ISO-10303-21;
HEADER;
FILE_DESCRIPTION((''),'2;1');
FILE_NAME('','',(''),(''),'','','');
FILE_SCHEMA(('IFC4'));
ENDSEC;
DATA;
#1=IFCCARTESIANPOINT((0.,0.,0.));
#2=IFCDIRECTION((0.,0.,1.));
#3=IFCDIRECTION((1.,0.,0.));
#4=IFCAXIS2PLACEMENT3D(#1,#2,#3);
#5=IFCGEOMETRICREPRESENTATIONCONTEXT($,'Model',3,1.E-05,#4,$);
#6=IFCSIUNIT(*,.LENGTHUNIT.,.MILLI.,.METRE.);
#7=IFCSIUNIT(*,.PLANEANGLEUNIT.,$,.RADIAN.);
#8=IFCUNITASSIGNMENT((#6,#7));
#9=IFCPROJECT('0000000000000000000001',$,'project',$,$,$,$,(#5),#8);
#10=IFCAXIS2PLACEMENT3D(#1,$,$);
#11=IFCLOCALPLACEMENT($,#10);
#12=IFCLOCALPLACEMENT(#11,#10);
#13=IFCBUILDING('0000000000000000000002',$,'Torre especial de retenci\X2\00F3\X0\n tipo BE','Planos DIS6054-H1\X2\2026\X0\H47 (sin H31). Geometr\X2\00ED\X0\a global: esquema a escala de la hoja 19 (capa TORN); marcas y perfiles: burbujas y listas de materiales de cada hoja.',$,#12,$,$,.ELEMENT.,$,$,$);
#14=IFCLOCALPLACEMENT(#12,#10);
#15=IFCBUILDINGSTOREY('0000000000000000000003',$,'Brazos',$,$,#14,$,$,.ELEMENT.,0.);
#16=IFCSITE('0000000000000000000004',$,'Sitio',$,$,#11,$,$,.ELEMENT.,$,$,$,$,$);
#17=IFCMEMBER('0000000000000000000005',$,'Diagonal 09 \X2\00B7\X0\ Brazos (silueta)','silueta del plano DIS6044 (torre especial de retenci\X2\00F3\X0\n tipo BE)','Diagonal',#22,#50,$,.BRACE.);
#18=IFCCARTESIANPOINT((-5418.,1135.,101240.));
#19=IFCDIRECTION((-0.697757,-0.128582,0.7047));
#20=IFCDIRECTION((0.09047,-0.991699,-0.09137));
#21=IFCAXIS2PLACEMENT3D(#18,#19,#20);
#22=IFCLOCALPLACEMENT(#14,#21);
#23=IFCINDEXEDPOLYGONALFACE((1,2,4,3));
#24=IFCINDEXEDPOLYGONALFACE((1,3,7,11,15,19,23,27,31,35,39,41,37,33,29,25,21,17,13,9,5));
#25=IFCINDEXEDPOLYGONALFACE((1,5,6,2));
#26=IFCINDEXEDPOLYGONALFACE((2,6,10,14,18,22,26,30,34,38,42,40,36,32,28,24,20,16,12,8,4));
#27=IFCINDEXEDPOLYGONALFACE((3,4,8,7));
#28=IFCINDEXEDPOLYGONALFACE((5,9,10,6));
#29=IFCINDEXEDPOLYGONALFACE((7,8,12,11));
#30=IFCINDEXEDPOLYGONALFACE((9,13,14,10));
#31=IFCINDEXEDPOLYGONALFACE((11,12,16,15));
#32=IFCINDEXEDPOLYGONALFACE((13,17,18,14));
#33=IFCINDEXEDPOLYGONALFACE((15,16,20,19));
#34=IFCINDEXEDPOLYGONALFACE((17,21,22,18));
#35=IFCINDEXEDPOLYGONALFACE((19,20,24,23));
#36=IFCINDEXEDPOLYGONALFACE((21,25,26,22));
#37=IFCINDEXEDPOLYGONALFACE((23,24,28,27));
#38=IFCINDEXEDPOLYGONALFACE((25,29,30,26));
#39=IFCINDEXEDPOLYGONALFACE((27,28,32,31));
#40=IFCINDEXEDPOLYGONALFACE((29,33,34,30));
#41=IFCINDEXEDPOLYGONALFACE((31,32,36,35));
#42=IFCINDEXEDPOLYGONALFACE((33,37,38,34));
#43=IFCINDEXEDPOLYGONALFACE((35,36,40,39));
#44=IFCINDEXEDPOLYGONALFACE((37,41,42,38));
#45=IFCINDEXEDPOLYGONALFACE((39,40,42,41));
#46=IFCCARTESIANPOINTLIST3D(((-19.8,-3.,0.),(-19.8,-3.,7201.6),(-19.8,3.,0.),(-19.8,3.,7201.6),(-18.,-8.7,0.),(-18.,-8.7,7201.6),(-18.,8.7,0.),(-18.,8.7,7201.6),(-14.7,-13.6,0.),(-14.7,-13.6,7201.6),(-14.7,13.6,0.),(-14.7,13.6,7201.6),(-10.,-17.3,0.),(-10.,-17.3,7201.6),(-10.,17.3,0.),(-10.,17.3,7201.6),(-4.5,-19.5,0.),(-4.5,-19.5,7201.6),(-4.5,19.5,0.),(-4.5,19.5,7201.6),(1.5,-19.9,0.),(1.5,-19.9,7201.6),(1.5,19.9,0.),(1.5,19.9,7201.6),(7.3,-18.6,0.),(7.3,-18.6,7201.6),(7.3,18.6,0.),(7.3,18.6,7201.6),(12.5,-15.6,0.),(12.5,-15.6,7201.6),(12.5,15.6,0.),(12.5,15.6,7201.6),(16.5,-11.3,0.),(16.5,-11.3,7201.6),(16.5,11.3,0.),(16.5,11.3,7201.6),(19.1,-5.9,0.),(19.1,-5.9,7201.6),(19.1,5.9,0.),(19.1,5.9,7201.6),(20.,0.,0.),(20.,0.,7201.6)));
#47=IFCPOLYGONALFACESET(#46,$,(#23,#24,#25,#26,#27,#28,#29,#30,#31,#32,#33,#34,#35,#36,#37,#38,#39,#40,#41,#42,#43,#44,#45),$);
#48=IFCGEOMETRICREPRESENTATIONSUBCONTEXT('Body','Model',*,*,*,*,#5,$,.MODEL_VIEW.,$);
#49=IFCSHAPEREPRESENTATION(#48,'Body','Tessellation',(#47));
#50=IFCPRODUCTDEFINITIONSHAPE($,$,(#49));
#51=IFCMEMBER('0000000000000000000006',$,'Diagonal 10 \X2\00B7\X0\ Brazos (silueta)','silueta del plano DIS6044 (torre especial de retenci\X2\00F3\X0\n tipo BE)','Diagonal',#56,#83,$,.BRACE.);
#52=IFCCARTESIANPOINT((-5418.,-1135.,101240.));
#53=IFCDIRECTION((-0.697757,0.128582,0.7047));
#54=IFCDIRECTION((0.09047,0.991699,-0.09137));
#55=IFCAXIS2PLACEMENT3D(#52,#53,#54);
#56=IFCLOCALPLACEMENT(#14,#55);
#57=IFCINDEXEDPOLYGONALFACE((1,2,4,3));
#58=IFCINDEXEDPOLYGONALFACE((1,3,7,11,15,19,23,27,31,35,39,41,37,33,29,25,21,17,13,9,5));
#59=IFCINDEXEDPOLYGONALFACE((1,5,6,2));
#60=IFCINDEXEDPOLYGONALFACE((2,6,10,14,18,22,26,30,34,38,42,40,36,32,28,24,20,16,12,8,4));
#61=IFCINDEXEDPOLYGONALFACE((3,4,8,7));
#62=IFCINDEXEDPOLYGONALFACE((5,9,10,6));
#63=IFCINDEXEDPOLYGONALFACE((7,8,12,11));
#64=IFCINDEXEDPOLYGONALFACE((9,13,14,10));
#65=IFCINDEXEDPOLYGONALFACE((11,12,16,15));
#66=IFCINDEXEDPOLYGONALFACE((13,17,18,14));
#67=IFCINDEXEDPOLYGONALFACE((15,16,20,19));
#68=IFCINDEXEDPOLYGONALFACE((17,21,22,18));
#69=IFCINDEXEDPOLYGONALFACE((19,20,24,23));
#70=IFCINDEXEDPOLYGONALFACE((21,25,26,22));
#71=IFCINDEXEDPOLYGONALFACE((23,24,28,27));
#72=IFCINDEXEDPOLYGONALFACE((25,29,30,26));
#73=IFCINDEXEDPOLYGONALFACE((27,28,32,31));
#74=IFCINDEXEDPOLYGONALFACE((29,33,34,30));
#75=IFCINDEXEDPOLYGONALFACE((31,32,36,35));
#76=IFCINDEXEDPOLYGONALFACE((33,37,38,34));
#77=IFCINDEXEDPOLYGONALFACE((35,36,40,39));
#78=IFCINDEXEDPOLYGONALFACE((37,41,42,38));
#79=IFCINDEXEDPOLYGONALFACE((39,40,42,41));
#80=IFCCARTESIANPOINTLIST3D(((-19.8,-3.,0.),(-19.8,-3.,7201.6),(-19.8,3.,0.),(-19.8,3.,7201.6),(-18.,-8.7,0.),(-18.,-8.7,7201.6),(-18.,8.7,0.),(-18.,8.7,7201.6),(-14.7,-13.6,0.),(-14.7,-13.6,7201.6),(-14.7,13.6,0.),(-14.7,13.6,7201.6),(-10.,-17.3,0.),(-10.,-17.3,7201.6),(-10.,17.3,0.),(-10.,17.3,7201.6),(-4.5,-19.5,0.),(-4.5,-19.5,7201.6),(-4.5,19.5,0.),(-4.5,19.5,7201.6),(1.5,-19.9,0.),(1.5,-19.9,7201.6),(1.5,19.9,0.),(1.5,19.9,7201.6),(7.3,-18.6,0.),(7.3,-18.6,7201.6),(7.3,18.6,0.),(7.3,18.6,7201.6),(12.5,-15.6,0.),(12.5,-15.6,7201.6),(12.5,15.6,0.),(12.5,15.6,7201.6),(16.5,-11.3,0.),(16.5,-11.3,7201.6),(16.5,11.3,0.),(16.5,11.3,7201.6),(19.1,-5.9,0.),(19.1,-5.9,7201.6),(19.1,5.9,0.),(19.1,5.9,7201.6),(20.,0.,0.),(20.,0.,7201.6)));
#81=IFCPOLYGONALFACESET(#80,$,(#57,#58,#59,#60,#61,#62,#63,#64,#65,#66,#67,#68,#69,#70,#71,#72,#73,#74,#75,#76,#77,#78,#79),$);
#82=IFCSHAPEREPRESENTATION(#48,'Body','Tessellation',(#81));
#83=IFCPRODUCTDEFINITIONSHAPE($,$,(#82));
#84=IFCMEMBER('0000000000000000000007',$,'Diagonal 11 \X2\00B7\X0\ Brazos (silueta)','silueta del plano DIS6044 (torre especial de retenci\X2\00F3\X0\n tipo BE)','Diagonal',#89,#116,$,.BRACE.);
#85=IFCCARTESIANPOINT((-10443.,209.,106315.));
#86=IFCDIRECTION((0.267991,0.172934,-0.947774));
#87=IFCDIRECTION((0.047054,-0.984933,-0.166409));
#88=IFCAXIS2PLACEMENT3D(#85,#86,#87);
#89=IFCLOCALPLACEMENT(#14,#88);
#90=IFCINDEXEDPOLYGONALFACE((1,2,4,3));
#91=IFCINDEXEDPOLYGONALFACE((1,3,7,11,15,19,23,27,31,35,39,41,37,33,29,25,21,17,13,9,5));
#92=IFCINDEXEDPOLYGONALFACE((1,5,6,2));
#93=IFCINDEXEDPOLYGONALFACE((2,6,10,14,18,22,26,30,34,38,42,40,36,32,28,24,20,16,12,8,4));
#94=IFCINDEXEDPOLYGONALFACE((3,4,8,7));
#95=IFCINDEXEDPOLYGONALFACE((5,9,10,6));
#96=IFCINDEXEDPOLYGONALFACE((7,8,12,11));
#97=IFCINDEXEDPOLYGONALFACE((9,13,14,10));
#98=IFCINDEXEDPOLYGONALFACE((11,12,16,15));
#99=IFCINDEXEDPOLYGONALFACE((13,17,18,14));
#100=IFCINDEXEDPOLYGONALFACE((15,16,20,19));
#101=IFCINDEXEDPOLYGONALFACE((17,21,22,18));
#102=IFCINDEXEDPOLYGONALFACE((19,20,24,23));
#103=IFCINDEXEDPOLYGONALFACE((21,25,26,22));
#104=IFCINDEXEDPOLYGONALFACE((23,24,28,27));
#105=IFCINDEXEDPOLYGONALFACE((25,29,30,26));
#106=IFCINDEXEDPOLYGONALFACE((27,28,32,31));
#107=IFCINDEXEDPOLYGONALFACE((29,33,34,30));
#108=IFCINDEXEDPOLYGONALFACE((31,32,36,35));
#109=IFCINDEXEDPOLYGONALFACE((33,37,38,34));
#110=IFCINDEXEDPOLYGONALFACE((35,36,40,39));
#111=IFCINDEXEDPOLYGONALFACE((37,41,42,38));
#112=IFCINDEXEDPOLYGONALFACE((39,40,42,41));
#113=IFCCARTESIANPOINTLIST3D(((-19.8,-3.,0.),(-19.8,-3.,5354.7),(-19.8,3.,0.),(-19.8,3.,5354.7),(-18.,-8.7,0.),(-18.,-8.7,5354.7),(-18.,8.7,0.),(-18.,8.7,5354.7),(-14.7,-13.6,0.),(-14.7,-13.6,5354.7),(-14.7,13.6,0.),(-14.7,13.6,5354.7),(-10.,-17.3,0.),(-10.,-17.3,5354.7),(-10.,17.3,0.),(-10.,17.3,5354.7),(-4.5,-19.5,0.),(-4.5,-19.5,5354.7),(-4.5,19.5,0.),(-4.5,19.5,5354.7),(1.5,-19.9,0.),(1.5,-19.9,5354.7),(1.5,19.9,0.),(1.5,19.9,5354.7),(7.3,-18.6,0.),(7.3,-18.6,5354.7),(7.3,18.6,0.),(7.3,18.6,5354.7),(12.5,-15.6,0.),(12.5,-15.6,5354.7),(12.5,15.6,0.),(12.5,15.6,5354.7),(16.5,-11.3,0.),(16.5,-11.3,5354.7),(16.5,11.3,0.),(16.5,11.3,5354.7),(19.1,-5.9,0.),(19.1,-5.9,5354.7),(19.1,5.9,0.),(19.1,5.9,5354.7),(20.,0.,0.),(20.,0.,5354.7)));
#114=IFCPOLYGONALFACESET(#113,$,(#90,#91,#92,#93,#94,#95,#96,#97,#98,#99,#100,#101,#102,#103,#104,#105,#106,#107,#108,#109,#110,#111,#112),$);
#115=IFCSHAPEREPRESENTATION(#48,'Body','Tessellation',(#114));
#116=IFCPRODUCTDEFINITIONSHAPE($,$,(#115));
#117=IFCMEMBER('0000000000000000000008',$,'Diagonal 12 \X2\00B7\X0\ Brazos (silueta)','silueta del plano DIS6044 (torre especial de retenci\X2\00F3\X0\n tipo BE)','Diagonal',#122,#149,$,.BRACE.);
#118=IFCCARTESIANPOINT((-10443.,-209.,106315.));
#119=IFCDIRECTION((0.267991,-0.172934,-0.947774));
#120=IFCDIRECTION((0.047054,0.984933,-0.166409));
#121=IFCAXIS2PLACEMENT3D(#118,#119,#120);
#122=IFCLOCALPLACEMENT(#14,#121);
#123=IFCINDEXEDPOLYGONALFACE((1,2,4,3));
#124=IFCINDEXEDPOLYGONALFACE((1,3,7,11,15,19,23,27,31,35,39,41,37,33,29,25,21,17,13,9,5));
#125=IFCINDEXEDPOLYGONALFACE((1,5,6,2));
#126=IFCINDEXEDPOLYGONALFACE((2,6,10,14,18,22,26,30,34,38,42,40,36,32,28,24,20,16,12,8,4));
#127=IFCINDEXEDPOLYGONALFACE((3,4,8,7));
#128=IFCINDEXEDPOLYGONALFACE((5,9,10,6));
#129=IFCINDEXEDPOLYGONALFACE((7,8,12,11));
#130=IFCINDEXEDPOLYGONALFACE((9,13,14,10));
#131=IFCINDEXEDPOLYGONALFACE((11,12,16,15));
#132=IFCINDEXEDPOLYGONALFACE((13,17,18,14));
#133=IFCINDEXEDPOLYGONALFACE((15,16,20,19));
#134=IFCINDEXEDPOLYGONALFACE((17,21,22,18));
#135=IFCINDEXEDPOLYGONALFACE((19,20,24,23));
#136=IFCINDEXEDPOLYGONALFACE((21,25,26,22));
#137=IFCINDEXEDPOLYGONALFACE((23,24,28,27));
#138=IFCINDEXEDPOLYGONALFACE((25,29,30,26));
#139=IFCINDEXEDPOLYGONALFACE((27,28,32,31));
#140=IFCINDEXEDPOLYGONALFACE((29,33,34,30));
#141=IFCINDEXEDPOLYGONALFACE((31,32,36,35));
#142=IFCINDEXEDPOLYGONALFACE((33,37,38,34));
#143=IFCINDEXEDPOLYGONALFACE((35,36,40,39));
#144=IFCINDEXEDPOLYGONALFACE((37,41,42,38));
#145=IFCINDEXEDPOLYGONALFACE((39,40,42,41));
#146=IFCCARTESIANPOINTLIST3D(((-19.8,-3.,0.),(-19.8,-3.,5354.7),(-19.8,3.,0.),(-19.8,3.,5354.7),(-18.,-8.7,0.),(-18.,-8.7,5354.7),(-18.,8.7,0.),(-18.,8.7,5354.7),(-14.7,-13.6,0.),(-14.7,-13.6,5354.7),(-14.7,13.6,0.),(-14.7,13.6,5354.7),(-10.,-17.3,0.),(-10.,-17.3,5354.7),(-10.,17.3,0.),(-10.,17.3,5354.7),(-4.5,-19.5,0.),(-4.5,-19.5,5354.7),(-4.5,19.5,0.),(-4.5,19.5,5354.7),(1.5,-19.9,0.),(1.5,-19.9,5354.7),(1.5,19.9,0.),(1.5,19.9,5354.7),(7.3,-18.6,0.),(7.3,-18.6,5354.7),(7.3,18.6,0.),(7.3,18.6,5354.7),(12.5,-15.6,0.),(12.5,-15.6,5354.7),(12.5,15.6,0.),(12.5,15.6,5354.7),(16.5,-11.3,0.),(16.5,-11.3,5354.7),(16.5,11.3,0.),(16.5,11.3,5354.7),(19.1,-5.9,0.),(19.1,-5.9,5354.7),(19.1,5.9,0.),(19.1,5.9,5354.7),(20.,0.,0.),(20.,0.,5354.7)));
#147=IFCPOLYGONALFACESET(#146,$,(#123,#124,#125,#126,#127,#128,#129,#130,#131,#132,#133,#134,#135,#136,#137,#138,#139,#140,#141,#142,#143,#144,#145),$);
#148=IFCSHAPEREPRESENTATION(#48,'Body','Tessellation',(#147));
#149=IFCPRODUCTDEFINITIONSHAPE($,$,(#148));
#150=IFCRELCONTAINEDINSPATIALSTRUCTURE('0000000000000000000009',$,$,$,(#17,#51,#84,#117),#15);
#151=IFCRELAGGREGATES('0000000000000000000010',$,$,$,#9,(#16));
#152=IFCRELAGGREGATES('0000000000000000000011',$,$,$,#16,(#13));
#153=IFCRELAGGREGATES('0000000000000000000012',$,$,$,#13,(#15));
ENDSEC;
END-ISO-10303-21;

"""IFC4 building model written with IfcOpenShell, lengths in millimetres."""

from ifc_helpers import new_model, si_unit, frame, origin, origin_with_axes, place, context, subcontext, project, spatial, circle, extrude, element, save


model = new_model("IFC4")

# Units and contexts
model_context = context("Model", 3, precision=1e-05, world=origin_with_axes())
body_context = subcontext(model_context, "Body", "Model", "MODEL_VIEW")
ifc_project = project(units=[si_unit("LENGTHUNIT", "METRE", prefix="MILLI"), si_unit("PLANEANGLEUNIT", "RADIAN")], contexts=[model_context])

# Site, building, storey
site_placement = place(None, origin())
site = spatial("IfcSite", under=ifc_project, at=site_placement, Name="Sitio", CompositionType="ELEMENT")
building_placement = place(site_placement, origin())
building = spatial("IfcBuilding", under=site, at=building_placement, Name="Torre especial de retención tipo BE", Description="Planos DIS6054-H1…H47 (sin H31). Geometría global: esquema a escala de la hoja 19 (capa TORN); marcas y perfiles: burbujas y listas de materiales de cada hoja.", CompositionType="ELEMENT")
storey_placement = place(building_placement, origin())
storey = spatial("IfcBuildingStorey", under=building, at=storey_placement, Name="Brazos", CompositionType="ELEMENT", Elevation=0.0)

# Members
for number, where, z_axis, x_axis, name in (
    (1, (-5418.0, 1135.0, 101240.0), (-0.697757, -0.128582, 0.7047), (0.09047, -0.991699, -0.09137), "Diagonal 09 · Brazos (silueta)"),
    (2, (-5418.0, -1135.0, 101240.0), (-0.697757, 0.128582, 0.7047), (0.09047, 0.991699, -0.09137), "Diagonal 10 · Brazos (silueta)"),
):
    element("IfcMember", number, at=place(storey_placement, frame(where, z_axis=z_axis, x_axis=x_axis)), inside=storey, Name=name, Description="silueta del plano DIS6044 (torre especial de retención tipo BE)", ObjectType="Diagonal", PredefinedType="BRACE", context=body_context, shape_type="SweptSolid", body=[
        extrude(circle(Radius=20.0), None, (0.0, 0.0, 1.0), 7201.6),
    ])
for number, where, z_axis, x_axis, name in (
    (3, (-10443.0, 209.0, 106315.0), (0.267991, 0.172934, -0.947774), (0.047054, -0.984933, -0.166409), "Diagonal 11 · Brazos (silueta)"),
    (4, (-10443.0, -209.0, 106315.0), (0.267991, -0.172934, -0.947774), (0.047054, 0.984933, -0.166409), "Diagonal 12 · Brazos (silueta)"),
):
    element("IfcMember", number, at=place(storey_placement, frame(where, z_axis=z_axis, x_axis=x_axis)), inside=storey, Name=name, Description="silueta del plano DIS6044 (torre especial de retención tipo BE)", ObjectType="Diagonal", PredefinedType="BRACE", context=body_context, shape_type="SweptSolid", body=[
        extrude(circle(Radius=20.0), None, (0.0, 0.0, 1.0), 5354.7),
    ])

save(model, "model.ifc")
